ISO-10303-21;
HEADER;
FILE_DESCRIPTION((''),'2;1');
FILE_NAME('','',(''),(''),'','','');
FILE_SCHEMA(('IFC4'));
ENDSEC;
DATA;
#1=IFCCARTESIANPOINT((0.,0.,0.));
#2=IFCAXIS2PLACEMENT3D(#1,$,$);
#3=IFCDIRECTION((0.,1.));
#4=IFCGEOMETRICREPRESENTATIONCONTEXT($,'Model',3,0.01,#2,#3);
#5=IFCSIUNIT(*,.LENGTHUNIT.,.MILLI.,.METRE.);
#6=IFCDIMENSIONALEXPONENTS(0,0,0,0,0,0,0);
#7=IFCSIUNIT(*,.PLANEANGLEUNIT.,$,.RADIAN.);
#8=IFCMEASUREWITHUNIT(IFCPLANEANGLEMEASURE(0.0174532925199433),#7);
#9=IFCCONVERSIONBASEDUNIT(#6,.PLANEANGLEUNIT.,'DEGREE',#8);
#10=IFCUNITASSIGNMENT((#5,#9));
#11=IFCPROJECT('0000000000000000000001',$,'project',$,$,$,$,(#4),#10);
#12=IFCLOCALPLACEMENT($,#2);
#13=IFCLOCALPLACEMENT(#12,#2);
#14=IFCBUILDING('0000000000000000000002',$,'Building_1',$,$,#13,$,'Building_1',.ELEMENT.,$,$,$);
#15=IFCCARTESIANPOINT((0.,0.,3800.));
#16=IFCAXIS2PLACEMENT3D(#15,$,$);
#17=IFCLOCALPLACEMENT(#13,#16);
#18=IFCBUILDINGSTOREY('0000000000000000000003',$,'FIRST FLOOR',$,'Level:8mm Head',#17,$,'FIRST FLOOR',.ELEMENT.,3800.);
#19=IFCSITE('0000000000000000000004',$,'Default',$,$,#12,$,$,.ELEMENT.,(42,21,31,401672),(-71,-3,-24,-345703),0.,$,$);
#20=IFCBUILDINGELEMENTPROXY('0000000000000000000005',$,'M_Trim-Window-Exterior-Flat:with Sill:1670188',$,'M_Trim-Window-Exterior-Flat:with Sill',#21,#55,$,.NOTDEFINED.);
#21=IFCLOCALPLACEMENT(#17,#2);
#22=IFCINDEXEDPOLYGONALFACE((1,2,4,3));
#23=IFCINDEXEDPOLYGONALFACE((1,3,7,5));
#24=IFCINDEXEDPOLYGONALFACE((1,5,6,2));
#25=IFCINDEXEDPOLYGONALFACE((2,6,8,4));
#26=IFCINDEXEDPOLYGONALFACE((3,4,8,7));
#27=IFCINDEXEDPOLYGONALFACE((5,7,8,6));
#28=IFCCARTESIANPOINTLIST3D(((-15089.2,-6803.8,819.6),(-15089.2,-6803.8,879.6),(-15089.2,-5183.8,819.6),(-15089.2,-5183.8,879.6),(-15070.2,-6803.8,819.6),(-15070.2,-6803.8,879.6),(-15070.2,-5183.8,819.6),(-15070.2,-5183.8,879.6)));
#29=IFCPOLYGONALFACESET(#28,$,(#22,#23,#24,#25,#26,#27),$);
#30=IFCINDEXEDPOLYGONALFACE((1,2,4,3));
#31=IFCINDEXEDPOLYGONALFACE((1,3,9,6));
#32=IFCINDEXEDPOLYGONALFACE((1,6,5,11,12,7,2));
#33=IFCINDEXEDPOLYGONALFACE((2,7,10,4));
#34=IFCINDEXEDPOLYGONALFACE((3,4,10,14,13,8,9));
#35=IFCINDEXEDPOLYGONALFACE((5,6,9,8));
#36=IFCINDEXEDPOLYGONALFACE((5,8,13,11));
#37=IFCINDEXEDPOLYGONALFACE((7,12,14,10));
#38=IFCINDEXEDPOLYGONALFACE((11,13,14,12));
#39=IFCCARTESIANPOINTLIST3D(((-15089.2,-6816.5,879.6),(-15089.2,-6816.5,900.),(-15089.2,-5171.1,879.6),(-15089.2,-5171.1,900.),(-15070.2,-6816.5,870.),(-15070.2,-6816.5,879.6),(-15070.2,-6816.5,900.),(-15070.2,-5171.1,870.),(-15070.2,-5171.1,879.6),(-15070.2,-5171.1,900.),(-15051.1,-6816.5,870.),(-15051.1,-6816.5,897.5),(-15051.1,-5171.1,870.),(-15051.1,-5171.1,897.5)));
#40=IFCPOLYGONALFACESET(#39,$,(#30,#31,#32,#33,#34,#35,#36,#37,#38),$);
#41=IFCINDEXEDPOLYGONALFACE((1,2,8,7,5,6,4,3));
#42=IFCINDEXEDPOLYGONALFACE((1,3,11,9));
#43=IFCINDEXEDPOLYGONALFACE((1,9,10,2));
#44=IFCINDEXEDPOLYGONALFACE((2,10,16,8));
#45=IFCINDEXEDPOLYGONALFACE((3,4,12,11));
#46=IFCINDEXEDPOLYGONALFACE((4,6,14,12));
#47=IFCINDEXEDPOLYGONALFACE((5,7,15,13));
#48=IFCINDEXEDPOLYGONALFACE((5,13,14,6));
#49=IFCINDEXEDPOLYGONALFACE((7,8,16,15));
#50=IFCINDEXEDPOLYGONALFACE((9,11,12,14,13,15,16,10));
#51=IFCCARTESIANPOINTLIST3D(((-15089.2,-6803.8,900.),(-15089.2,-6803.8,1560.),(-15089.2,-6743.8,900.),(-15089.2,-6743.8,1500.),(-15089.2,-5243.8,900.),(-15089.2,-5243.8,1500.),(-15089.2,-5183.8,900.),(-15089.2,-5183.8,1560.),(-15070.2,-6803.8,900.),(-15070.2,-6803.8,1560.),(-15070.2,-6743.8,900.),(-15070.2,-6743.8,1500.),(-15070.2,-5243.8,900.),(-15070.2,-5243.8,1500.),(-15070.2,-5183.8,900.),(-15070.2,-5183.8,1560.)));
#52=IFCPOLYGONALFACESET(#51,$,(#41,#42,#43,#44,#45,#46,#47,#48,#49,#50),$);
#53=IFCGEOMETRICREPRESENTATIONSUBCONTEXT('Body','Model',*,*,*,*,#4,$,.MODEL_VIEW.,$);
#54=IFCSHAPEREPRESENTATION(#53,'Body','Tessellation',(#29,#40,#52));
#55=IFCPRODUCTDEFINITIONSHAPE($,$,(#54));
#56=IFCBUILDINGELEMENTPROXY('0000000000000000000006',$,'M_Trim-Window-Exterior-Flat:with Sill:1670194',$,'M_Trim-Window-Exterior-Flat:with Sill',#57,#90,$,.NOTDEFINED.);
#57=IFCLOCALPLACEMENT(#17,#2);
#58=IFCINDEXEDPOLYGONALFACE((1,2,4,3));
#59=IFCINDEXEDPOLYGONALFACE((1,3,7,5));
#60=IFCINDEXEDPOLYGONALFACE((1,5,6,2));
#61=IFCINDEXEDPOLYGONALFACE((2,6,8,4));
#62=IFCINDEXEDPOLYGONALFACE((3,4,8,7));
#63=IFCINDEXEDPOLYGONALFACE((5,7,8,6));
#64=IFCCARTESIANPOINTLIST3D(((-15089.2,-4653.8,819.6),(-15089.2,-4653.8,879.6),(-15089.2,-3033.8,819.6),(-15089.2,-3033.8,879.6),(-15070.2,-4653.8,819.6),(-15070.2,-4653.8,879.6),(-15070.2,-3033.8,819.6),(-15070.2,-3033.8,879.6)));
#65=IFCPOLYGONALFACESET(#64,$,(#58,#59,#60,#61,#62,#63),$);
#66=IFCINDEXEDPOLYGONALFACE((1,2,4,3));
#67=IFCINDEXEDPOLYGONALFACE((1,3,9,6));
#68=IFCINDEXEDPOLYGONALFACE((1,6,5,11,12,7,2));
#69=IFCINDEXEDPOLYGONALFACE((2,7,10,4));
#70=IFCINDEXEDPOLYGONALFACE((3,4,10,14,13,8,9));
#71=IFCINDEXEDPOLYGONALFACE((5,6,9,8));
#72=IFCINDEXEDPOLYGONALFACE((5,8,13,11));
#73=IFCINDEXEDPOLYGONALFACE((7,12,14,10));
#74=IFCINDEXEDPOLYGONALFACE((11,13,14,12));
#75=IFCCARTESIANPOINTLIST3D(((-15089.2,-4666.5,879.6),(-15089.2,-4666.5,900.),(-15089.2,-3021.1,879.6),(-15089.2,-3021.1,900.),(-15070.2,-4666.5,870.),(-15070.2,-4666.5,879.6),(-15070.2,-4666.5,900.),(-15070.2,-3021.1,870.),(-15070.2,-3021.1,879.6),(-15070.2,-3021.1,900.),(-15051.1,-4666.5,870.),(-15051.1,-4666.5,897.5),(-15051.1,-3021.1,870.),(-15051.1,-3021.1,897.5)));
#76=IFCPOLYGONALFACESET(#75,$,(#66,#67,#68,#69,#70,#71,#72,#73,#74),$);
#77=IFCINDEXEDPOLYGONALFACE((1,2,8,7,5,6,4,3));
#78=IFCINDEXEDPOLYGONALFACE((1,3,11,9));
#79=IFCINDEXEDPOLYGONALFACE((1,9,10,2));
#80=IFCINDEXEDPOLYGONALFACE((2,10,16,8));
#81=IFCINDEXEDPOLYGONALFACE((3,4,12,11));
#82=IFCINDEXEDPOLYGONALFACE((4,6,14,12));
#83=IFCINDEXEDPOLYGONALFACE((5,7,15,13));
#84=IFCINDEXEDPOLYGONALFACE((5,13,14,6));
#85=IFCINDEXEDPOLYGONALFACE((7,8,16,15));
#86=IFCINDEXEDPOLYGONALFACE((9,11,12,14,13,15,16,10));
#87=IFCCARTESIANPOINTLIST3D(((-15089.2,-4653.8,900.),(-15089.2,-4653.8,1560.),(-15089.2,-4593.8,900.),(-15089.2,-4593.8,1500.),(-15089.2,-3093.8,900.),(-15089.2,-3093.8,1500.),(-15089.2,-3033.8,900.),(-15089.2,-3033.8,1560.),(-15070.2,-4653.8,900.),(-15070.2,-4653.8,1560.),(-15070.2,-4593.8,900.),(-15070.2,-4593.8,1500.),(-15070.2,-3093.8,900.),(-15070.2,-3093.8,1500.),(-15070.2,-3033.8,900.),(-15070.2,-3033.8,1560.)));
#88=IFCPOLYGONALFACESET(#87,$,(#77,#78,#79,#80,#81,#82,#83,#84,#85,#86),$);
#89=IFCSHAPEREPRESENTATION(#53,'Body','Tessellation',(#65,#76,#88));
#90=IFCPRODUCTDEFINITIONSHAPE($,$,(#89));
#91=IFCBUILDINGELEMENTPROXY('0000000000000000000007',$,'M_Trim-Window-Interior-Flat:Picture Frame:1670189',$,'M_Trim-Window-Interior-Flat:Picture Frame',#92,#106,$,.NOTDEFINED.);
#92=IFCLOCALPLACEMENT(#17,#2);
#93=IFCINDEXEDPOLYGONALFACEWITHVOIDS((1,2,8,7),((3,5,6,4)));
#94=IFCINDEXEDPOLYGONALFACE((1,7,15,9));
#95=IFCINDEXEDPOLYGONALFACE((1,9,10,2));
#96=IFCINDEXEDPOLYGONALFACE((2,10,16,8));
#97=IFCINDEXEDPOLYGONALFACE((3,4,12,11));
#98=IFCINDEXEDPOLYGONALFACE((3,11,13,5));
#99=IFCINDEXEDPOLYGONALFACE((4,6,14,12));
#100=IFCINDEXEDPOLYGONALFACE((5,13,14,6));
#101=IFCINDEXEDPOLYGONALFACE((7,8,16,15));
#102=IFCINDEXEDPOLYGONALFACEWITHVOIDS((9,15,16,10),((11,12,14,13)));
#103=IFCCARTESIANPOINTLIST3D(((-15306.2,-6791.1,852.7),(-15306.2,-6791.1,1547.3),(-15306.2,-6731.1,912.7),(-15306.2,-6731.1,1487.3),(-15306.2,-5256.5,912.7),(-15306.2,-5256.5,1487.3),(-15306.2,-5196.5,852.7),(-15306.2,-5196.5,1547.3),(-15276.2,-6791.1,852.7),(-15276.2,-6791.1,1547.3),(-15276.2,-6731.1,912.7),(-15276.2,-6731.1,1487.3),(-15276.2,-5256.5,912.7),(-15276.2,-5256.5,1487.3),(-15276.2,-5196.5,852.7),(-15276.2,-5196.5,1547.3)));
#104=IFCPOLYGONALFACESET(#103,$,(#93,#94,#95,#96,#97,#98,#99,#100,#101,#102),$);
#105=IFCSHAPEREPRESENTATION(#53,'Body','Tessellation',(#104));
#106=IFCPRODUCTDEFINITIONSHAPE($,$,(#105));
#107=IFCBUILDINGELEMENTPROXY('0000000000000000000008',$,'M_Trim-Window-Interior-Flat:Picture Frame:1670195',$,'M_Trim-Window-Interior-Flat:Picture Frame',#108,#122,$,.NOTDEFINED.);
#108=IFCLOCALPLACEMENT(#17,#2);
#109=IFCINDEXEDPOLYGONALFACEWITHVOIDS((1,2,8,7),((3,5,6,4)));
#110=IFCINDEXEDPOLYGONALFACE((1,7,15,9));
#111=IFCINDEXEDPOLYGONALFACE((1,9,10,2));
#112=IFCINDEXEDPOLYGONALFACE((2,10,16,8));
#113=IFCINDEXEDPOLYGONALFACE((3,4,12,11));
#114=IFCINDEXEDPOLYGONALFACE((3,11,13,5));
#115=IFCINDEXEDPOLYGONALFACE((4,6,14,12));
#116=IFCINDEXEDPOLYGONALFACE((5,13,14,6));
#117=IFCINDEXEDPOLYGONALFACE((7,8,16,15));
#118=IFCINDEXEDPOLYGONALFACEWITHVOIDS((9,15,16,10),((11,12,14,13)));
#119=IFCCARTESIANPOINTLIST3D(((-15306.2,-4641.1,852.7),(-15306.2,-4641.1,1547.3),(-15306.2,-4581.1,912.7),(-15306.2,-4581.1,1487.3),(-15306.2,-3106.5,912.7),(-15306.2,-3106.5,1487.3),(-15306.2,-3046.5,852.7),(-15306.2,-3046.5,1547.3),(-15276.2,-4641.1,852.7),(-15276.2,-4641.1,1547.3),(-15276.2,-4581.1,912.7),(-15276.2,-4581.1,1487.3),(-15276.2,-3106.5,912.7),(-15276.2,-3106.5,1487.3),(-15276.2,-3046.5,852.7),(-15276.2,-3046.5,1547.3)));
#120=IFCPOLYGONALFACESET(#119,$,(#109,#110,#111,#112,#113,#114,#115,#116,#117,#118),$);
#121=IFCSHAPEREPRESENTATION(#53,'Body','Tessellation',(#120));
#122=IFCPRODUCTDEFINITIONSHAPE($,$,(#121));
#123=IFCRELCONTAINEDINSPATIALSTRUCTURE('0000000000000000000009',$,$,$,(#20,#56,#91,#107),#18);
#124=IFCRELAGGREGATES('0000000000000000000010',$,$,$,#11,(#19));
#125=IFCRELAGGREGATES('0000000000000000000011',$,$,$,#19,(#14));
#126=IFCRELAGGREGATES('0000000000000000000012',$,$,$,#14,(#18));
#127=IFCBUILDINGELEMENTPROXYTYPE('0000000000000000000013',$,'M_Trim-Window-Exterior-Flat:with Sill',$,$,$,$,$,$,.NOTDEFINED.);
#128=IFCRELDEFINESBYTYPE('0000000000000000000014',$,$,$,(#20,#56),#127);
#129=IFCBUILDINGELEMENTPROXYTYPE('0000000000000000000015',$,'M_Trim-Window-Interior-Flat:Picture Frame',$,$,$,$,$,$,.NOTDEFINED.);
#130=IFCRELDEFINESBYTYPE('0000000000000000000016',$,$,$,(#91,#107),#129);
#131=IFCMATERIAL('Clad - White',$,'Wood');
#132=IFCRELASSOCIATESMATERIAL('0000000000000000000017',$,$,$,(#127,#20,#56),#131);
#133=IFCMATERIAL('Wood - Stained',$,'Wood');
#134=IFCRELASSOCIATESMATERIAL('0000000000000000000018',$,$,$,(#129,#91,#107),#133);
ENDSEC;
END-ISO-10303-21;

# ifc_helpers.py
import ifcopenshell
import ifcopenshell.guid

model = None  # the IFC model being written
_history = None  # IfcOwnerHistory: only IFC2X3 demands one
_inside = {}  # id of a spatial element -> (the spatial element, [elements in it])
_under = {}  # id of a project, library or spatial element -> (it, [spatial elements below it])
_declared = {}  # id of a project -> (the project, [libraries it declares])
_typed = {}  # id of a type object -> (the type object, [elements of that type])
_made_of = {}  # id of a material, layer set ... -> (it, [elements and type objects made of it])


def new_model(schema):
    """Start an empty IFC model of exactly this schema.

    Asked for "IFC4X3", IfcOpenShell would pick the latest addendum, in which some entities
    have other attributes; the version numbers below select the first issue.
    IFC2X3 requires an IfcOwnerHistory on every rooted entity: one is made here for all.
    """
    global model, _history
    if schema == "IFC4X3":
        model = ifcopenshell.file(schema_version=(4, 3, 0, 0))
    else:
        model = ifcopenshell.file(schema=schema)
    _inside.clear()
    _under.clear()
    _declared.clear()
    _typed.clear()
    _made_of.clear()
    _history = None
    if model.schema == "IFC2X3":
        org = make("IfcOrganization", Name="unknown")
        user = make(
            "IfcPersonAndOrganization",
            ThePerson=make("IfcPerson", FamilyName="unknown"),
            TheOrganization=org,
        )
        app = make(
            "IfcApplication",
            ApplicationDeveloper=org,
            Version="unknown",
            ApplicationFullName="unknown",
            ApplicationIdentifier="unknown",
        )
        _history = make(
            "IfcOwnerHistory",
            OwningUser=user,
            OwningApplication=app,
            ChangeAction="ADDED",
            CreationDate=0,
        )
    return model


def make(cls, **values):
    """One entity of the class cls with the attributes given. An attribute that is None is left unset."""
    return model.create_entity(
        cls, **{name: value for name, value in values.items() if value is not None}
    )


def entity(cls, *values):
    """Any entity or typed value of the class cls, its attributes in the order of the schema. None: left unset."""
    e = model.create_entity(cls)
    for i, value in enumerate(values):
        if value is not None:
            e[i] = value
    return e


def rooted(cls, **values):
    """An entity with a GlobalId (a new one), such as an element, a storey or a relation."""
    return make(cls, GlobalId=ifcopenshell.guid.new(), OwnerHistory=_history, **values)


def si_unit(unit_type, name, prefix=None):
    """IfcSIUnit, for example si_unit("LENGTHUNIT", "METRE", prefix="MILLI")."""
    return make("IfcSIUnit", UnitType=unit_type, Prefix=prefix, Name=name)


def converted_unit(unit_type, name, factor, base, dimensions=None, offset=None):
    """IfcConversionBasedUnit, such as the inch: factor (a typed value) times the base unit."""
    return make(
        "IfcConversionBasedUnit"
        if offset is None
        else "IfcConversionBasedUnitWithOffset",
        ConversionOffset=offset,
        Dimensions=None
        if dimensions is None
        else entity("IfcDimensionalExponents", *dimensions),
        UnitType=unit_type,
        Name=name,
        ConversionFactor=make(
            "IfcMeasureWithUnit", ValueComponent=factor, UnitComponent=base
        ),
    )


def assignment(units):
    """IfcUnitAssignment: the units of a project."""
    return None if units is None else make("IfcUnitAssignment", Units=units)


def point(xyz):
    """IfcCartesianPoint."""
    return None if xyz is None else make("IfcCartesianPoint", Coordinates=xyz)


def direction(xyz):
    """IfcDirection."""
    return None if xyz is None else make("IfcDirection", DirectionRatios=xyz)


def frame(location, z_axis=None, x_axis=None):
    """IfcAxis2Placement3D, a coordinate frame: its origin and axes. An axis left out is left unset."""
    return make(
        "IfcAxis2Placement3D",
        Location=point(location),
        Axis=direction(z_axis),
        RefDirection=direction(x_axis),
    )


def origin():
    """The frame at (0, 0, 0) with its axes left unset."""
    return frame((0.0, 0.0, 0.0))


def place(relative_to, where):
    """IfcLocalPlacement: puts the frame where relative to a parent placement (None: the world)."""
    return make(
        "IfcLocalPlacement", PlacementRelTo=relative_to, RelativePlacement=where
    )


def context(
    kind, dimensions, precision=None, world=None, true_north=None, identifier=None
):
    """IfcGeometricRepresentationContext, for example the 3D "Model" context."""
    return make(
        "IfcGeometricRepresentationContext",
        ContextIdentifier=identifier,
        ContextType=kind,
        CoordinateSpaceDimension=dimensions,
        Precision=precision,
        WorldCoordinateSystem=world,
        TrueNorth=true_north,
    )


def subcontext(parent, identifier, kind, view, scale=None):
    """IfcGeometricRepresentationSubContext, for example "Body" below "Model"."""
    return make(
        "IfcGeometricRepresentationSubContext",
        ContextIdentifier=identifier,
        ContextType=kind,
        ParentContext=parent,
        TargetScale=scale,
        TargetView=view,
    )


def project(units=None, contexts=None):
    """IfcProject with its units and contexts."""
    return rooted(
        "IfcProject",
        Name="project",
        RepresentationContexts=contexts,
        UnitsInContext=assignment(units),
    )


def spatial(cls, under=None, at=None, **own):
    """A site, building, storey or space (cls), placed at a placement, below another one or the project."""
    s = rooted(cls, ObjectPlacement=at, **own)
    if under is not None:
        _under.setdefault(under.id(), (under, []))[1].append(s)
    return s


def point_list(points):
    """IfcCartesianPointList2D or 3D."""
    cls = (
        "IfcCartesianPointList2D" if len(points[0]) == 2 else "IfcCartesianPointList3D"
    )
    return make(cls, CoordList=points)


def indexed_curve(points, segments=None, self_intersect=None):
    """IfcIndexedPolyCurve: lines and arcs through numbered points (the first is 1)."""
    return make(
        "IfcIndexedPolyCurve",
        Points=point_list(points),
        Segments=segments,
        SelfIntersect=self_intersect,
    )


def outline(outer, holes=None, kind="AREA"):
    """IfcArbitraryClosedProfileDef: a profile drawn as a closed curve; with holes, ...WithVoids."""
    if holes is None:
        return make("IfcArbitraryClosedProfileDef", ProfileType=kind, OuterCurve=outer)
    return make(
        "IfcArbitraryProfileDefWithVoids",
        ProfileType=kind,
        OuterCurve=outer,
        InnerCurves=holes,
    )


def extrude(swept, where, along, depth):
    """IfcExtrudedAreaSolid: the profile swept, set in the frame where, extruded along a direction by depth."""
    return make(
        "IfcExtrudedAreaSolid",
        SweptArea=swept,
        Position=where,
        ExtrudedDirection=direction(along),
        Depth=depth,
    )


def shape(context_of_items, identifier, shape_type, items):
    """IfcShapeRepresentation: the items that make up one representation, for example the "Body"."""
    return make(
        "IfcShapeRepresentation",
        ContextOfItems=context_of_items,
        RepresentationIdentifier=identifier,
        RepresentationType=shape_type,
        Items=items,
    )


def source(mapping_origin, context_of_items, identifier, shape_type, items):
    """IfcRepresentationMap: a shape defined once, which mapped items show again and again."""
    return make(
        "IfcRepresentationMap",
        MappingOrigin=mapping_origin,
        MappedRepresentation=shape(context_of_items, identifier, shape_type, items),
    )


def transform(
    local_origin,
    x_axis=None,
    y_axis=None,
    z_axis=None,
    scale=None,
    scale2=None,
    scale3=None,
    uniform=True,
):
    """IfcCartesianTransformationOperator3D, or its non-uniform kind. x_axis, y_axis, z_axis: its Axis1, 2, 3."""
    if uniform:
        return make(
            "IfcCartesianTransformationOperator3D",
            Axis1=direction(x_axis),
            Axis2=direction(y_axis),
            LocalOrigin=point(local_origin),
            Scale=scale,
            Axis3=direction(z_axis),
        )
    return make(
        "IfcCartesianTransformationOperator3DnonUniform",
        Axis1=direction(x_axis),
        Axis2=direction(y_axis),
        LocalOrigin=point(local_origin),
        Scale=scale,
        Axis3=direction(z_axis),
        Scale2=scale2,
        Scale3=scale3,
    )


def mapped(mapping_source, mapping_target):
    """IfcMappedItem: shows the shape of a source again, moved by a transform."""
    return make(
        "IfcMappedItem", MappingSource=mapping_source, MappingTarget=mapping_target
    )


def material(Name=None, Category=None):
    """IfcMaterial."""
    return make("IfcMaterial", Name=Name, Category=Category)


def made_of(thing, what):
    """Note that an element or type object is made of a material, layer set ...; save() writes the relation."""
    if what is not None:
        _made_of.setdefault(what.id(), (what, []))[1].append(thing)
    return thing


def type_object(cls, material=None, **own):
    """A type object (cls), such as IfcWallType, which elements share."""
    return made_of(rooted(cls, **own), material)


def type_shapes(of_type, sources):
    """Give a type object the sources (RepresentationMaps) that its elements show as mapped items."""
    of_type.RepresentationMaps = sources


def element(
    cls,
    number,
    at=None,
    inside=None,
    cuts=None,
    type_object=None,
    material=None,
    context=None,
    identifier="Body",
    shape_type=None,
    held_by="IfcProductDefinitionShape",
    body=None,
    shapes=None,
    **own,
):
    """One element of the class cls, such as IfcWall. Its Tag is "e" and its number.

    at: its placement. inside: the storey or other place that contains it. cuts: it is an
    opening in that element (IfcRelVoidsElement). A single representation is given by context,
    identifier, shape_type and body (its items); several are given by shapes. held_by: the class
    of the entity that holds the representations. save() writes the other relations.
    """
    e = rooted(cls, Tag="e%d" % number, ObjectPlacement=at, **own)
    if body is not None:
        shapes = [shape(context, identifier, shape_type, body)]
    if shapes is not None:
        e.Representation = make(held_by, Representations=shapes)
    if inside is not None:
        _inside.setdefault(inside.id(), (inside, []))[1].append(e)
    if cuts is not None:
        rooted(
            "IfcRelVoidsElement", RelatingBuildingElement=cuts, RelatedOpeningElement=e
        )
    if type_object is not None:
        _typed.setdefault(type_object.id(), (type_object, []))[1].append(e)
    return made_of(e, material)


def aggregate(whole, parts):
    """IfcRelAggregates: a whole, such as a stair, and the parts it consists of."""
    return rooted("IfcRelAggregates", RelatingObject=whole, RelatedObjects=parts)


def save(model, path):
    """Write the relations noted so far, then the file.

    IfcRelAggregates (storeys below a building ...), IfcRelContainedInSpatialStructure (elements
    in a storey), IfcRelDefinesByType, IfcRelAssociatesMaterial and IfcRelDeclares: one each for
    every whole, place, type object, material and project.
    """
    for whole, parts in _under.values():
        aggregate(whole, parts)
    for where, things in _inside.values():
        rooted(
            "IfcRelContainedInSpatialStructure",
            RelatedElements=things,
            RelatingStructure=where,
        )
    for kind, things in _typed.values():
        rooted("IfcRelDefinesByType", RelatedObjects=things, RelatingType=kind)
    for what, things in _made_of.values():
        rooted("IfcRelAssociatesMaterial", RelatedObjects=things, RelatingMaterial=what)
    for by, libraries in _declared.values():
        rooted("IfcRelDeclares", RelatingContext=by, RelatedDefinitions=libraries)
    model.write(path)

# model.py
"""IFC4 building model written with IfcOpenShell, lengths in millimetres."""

from ifc_helpers import new_model, entity, si_unit, converted_unit, direction, frame, origin, place, context, subcontext, project, spatial, indexed_curve, outline, extrude, source, transform, mapped, material, type_object, type_shapes, element, save


model = new_model("IFC4")

# Units and contexts
model_context = context("Model", 3, precision=0.01, world=origin(), true_north=direction((0.0, 1.0)))
body_context = subcontext(model_context, "Body", "Model", "MODEL_VIEW")
ifc_project = project(units=[si_unit("LENGTHUNIT", "METRE", prefix="MILLI"), converted_unit("PLANEANGLEUNIT", "DEGREE", entity("IfcPlaneAngleMeasure", 0.0174532925199433), si_unit("PLANEANGLEUNIT", "RADIAN"), dimensions=[0, 0, 0, 0, 0, 0, 0])], contexts=[model_context])

# Site, building, storey
site_placement = place(None, origin())
site = spatial("IfcSite", under=ifc_project, at=site_placement, Name="Default", CompositionType="ELEMENT", RefLatitude=(42, 21, 31, 401672), RefLongitude=(-71, -3, -24, -345703), RefElevation=0.0)
building_placement = place(site_placement, origin())
building = spatial("IfcBuilding", under=site, at=building_placement, Name="Building_1", LongName="Building_1", CompositionType="ELEMENT")
storey_placement = place(building_placement, frame((0.0, 0.0, 3800.0)))
storey = spatial("IfcBuildingStorey", under=building, at=storey_placement, Name="FIRST FLOOR", ObjectType="Level:8mm Head", LongName="FIRST FLOOR", CompositionType="ELEMENT", Elevation=3800.0)

# Shared definitions
ifc_material_1 = material(Name="Wood - Stained", Category="Wood")

# Building element proxies
ifc_material_2 = material(Name="Clad - White", Category="Wood")
building_element_proxy_type_1 = type_object("IfcBuildingElementProxyType", Name="M_Trim-Window-Exterior-Flat:with Sill", PredefinedType="NOTDEFINED", material=ifc_material_2)
shared_shape_1 = source(origin(), body_context, "Body", "SweptSolid", [
    extrude(outline(indexed_curve([(-810.0, -30.0), (810.0, -30.0), (810.0, 30.0), (-810.0, 30.0), (-810.0, -30.0)], self_intersect=False)), frame((0.0, -650.4, 0.0), z_axis=(0.0, 0.0, 1.0), x_axis=(-1.0, 0.0, 0.0)), (0.0, 0.0, 1.0), 19.1),
    extrude(outline(indexed_curve([(-19.0, -15.2), (0.0, -15.2), (0.0, -5.7), (19.0, -5.7), (19.0, 14.8), (0.0, 14.8), (-19.0, 12.3), (-19.0, -15.2)], self_intersect=False)), frame((-822.7, -614.8, 19.0), z_axis=(1.0, 0.0, 0.0), x_axis=(0.0, 0.0, -1.0)), (0.0, 0.0, 1.0), 1645.4),
    extrude(outline(indexed_curve([(-345.0, -810.0), (315.0, -810.0), (315.0, -750.0), (-285.0, -750.0), (-285.0, 750.0), (315.0, 750.0), (315.0, 810.0), (-345.0, 810.0), (-345.0, -810.0)], self_intersect=False)), frame((0.0, -285.0, 0.0), z_axis=(0.0, 0.0, 1.0), x_axis=(0.0, -1.0, 0.0)), (0.0, 0.0, 1.0), 19.1),
])
type_shapes(building_element_proxy_type_1, [shared_shape_1])
for number, where, z_axis, x_axis, name in (
    (1, (-15089.2, -5993.8, 1500.0), (1.0, 0.0, 0.0), (0.0, 1.0, 0.0), "M_Trim-Window-Exterior-Flat:with Sill:1670188"),
    (2, (-15089.2, -3843.8, 1500.0), (1.0, 0.0, 0.0), (0.0, 1.0, 0.0), "M_Trim-Window-Exterior-Flat:with Sill:1670194"),
):
    element("IfcBuildingElementProxy", number, at=place(storey_placement, frame(where, z_axis=z_axis, x_axis=x_axis)), inside=storey, type_object=building_element_proxy_type_1, material=ifc_material_2, Name=name, ObjectType="M_Trim-Window-Exterior-Flat:with Sill", PredefinedType="NOTDEFINED", context=body_context, shape_type="MappedRepresentation", body=[
        mapped(shared_shape_1, transform((0.0, 0.0, 0.0), scale=1.0)),
    ])
building_element_proxy_type_2 = type_object("IfcBuildingElementProxyType", Name="M_Trim-Window-Interior-Flat:Picture Frame", PredefinedType="NOTDEFINED", material=ifc_material_1)
shared_shape_2 = source(origin(), body_context, "Body", "SweptSolid", [
    extrude(outline(indexed_curve([(-797.3, -347.3), (797.3, -347.3), (797.3, 347.3), (-797.3, 347.3), (-797.3, -347.3)], self_intersect=False), holes=[indexed_curve([(-737.3, -287.3), (-737.3, 287.3), (737.3, 287.3), (737.3, -287.3), (-737.3, -287.3)], self_intersect=False)]), frame((0.0, -300.0, 0.0), z_axis=(0.0, 0.0, 1.0), x_axis=(-1.0, 0.0, 0.0)), (0.0, 0.0, 1.0), 30.0),
])
type_shapes(building_element_proxy_type_2, [shared_shape_2])
for number, where, z_axis, x_axis, name in (
    (3, (-15276.2, -5993.8, 1500.0), (-1.0, 0.0, 0.0), (0.0, -1.0, 0.0), "M_Trim-Window-Interior-Flat:Picture Frame:1670189"),
    (4, (-15276.2, -3843.8, 1500.0), (-1.0, 0.0, 0.0), (0.0, -1.0, 0.0), "M_Trim-Window-Interior-Flat:Picture Frame:1670195"),
):
    element("IfcBuildingElementProxy", number, at=place(storey_placement, frame(where, z_axis=z_axis, x_axis=x_axis)), inside=storey, type_object=building_element_proxy_type_2, material=ifc_material_1, Name=name, ObjectType="M_Trim-Window-Interior-Flat:Picture Frame", PredefinedType="NOTDEFINED", context=body_context, shape_type="MappedRepresentation", body=[
        mapped(shared_shape_2, transform((0.0, 0.0, 0.0), scale=1.0)),
    ])

save(model, "model.ifc")
